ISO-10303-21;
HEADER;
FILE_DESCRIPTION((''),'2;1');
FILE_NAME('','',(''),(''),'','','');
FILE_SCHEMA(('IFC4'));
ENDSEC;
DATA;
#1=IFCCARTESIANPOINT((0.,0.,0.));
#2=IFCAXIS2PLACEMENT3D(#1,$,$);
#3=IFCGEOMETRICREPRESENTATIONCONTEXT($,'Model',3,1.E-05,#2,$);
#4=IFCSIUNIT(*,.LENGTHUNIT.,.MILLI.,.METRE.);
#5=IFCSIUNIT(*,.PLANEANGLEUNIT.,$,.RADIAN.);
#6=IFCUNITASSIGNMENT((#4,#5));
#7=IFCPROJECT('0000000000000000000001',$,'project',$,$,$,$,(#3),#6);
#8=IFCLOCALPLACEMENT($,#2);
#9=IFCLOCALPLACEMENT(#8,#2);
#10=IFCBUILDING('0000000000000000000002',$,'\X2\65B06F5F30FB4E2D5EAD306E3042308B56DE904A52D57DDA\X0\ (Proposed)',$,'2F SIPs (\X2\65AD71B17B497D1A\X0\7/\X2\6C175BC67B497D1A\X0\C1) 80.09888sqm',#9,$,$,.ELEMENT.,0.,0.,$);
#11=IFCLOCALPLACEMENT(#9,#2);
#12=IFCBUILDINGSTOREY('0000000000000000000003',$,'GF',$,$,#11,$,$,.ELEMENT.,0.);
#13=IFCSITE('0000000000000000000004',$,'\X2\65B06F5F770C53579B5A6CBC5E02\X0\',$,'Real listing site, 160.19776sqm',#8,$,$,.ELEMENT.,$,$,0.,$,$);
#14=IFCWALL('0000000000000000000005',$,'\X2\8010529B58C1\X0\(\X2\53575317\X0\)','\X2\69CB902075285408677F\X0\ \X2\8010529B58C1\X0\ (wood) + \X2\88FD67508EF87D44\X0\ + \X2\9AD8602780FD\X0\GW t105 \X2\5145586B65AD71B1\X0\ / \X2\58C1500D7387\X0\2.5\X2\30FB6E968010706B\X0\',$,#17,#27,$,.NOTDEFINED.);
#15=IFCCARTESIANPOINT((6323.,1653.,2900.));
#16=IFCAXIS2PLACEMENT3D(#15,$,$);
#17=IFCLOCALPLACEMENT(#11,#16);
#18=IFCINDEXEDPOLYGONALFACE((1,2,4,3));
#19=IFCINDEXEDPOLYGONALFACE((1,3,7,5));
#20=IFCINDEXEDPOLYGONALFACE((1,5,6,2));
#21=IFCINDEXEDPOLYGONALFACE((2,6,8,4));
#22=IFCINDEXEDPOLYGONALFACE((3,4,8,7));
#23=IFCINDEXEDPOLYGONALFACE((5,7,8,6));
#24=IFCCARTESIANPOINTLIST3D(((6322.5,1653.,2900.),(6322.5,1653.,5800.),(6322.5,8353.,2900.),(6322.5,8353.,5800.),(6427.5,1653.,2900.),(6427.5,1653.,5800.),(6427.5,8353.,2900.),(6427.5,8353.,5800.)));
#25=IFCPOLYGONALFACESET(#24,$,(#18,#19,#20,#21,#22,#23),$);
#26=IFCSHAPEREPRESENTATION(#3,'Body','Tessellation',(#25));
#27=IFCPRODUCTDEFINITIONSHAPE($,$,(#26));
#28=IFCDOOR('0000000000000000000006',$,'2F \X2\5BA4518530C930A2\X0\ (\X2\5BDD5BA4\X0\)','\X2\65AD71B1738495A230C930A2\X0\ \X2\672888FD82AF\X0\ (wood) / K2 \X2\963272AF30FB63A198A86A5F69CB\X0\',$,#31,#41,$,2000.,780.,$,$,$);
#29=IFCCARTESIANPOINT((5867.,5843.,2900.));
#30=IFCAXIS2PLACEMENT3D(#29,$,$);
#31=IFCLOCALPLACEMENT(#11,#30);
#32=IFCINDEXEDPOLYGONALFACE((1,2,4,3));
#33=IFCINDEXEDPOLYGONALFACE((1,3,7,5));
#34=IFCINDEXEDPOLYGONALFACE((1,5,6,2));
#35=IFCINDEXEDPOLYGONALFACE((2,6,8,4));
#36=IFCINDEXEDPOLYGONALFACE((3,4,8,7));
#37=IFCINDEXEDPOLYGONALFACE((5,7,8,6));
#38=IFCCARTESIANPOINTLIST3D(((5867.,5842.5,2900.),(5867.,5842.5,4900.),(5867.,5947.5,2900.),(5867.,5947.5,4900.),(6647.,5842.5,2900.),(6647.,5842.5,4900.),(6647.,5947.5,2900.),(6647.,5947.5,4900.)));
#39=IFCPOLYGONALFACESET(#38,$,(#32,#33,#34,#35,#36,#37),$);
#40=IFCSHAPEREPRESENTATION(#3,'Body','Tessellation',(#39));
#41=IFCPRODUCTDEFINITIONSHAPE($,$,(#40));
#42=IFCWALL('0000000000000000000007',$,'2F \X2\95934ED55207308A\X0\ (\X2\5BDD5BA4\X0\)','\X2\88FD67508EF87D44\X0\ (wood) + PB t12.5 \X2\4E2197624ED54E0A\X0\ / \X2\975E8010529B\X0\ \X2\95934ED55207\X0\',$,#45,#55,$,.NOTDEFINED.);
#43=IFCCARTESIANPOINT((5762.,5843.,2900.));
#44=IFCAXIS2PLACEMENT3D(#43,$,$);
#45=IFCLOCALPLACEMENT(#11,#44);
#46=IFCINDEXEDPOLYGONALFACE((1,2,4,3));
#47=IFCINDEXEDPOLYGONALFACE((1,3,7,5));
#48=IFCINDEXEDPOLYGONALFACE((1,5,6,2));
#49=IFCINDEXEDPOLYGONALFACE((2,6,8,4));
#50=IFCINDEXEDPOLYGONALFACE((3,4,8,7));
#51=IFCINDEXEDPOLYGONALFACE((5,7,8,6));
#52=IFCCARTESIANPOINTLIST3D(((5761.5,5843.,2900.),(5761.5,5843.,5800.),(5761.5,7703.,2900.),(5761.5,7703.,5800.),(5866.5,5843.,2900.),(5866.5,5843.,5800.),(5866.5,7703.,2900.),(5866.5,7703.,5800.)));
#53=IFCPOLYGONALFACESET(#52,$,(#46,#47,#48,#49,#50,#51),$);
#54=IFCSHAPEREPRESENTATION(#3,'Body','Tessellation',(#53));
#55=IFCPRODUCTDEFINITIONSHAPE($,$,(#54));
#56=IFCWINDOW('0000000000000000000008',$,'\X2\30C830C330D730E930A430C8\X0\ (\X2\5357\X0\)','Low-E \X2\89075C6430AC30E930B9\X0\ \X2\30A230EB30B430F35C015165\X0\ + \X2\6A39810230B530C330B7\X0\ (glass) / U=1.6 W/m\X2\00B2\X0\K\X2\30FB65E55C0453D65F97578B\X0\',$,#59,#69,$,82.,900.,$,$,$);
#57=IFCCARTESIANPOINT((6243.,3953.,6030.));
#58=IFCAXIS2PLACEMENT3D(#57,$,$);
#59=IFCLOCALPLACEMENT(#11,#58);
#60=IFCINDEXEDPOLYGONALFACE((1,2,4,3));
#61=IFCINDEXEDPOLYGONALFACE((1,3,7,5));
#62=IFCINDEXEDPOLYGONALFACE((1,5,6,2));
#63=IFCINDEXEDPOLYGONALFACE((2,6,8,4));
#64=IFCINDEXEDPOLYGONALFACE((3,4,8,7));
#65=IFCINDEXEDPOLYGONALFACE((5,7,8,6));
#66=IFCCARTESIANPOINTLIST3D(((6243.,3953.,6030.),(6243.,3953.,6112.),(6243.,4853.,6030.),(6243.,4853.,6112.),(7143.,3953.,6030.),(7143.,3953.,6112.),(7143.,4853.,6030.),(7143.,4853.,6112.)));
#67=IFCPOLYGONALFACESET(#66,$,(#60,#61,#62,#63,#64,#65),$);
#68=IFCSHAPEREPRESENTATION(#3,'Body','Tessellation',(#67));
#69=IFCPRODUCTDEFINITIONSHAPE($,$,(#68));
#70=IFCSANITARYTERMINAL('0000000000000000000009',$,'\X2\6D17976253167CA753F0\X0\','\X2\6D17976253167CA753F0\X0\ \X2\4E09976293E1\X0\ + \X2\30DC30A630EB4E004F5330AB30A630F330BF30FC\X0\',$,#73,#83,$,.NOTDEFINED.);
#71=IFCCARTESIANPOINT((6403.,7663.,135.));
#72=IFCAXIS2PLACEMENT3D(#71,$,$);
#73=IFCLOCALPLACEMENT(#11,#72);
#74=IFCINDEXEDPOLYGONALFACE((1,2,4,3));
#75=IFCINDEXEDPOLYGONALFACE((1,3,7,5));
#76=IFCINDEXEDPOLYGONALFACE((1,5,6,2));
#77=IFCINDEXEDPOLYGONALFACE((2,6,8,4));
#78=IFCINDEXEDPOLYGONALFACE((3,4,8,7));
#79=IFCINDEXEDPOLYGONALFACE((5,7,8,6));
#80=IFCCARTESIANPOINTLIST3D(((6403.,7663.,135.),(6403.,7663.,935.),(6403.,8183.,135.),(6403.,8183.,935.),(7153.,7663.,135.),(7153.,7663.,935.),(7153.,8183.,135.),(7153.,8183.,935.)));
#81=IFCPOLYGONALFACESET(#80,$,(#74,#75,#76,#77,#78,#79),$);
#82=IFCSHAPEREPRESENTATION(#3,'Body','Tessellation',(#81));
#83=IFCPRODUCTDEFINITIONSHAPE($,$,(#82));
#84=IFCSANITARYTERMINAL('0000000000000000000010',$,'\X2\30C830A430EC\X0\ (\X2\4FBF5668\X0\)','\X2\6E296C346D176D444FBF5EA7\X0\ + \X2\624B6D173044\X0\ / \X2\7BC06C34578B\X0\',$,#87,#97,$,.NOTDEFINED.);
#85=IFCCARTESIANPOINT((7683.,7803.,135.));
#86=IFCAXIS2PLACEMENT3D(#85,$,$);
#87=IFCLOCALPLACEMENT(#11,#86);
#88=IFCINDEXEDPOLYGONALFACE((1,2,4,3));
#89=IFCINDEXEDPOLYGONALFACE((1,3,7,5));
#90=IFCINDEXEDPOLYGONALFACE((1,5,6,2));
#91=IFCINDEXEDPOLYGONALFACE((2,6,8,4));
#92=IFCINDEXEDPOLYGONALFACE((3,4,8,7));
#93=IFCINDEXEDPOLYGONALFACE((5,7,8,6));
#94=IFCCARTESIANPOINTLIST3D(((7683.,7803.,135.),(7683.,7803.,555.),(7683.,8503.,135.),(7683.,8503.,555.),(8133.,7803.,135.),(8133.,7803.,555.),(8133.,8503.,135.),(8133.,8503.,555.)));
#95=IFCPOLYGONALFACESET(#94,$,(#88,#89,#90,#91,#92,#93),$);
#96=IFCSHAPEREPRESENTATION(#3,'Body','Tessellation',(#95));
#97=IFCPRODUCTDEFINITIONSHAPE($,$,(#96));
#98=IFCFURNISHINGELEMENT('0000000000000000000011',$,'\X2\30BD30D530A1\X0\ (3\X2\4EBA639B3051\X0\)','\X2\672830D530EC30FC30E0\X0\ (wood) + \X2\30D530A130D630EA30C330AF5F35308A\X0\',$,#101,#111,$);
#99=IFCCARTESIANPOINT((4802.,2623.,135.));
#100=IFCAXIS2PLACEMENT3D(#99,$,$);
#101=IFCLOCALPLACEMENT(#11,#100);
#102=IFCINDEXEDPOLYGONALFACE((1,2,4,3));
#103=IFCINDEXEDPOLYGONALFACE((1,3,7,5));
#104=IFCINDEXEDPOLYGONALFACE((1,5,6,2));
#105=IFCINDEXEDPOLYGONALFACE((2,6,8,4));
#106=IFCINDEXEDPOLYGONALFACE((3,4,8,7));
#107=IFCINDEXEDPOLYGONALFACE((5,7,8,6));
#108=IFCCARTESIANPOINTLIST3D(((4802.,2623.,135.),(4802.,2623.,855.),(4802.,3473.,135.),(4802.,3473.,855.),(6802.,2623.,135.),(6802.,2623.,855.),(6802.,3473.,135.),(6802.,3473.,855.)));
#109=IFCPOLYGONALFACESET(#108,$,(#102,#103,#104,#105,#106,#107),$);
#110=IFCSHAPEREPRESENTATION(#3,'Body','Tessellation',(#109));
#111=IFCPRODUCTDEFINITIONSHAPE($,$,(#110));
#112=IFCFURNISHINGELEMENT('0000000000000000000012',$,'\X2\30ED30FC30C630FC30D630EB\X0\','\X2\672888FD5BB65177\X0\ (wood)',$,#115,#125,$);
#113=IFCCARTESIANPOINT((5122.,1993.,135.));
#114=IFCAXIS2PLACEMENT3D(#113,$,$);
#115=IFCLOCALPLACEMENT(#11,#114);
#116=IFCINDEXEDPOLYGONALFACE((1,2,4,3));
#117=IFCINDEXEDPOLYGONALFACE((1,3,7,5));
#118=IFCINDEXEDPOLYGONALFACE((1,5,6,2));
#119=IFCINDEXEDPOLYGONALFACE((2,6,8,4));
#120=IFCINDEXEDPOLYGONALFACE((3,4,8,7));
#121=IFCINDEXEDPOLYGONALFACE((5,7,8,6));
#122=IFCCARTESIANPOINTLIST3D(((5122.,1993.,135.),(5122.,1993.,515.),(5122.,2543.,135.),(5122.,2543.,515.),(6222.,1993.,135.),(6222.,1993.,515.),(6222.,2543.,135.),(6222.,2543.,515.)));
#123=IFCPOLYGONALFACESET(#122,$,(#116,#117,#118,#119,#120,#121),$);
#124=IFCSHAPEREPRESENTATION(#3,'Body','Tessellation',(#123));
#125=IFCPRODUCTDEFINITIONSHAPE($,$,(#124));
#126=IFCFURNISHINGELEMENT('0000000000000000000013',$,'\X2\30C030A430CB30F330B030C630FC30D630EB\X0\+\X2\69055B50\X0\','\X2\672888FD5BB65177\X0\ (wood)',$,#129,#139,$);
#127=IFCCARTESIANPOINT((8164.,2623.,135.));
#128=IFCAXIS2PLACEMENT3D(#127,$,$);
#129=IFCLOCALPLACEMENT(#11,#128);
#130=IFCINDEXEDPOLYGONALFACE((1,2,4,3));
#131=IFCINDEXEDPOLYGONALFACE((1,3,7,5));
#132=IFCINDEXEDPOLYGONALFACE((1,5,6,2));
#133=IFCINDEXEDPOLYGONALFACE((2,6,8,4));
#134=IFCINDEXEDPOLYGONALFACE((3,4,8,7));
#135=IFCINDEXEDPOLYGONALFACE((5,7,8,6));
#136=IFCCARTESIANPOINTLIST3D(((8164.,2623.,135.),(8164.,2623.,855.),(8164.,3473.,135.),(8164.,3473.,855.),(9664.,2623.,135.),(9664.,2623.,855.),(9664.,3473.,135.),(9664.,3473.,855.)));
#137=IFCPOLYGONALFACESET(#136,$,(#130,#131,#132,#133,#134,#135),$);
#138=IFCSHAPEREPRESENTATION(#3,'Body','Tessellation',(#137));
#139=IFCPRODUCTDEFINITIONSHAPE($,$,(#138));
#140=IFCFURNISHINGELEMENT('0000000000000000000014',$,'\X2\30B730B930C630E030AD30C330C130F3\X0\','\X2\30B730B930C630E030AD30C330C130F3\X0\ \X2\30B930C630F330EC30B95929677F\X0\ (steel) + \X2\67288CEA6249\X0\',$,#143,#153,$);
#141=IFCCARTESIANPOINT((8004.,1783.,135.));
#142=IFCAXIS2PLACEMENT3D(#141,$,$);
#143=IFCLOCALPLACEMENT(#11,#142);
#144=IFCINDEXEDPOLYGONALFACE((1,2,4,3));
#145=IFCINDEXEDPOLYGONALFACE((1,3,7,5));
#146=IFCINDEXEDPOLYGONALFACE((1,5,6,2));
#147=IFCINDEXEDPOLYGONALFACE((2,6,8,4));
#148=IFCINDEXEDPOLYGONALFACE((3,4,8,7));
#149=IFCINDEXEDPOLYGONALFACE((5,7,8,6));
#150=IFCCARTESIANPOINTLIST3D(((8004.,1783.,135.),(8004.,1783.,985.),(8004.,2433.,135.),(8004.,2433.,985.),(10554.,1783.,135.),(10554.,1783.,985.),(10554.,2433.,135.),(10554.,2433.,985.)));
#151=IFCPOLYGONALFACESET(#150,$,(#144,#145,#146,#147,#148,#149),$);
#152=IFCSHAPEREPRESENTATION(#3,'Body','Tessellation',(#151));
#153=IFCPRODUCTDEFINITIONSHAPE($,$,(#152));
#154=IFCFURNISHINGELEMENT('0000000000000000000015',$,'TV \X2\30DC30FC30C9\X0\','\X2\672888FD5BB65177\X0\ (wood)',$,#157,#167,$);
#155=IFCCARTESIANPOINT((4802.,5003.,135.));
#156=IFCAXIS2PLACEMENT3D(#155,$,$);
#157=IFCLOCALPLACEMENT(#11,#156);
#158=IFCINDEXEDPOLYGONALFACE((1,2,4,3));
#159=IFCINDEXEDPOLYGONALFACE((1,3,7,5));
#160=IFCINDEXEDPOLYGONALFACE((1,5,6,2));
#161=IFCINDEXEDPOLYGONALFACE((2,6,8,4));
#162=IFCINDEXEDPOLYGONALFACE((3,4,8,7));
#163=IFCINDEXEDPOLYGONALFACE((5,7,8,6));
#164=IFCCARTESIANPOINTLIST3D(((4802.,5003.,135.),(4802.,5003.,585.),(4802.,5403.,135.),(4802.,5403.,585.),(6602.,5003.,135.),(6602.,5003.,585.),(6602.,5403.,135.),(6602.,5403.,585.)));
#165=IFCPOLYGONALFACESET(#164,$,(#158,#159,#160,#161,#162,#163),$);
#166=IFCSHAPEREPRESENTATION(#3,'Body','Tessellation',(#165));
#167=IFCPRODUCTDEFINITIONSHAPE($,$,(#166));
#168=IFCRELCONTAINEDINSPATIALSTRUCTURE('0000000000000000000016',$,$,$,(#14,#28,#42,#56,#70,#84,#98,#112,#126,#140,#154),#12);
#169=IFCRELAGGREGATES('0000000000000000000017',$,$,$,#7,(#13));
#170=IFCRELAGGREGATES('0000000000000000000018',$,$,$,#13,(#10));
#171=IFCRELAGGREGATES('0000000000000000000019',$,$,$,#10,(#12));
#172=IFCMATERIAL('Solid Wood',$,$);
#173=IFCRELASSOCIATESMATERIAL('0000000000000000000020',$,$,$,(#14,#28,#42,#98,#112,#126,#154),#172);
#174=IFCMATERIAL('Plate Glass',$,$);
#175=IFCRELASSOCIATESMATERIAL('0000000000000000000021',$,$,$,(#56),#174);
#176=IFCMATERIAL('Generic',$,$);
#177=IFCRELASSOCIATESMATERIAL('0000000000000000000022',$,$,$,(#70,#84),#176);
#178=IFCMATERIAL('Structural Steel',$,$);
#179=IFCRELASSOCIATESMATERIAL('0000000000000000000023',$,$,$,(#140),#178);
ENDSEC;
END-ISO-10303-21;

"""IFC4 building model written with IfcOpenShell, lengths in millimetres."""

from ifc_helpers import new_model, si_unit, frame, frame_2d, origin, place, context, project, spatial, rectangle, extrude, material, element, fill, save


model = new_model("IFC4")

# Units and contexts
model_context = context("Model", 3, precision=1e-05, world=origin())
ifc_project = project(units=[si_unit("LENGTHUNIT", "METRE", prefix="MILLI"), si_unit("PLANEANGLEUNIT", "RADIAN")], contexts=[model_context])

# Site, building, storey
site_placement = place(None, origin())
site = spatial("IfcSite", under=ifc_project, at=site_placement, Name="新潟県南魚沼市", ObjectType="Real listing site, 160.19776sqm", CompositionType="ELEMENT", RefElevation=0.0)
building_placement = place(site_placement, origin())
building = spatial("IfcBuilding", under=site, at=building_placement, Name="新潟・中庭のある回遊動線 (Proposed)", ObjectType="2F SIPs (断熱等級7/気密等級C1) 80.09888sqm", CompositionType="ELEMENT", ElevationOfRefHeight=0.0, ElevationOfTerrain=0.0)
storey_placement = place(building_placement, origin())
storey = spatial("IfcBuildingStorey", under=building, at=storey_placement, Name="GF", CompositionType="ELEMENT", Elevation=0.0)

# Shared definitions
ifc_material_1 = material(Name="Solid Wood")

# Wall, opening, door
wall_1_placement = place(storey_placement, frame((6323.0, 1653.0, 2900.0)))
wall_1 = element("IfcWall", 1, at=wall_1_placement, inside=storey, material=ifc_material_1, Name="耐力壁(南北)", Description="構造用合板 耐力壁 (wood) + 製材軸組 + 高性能GW t105 充填断熱 / 壁倍率2.5・準耐火", PredefinedType="NOTDEFINED", context=model_context, shape_type="SweptSolid", body=[
    extrude(rectangle(XDim=105.0, YDim=6700.0, at=frame_2d((52.0, 3350.0))), frame((6323.0, 1653.0, 2900.0)), (0.0, 0.0, 1.0), 2900.0),
])
opening_1_placement = place(storey_placement, frame((5867.0, 5843.0, 2900.0)))
opening_1 = element("IfcOpeningElement", 2, at=opening_1_placement, cuts=wall_1, PredefinedType="NOTDEFINED", context=model_context, shape_type="SweptSolid", body=[
    extrude(rectangle(XDim=780.0, YDim=105.0, at=frame_2d((390.0, 52.0))), frame((5867.0, 5843.0, 2900.0)), (0.0, 0.0, 1.0), 2000.0),
])
door_1_placement = place(storey_placement, frame((5867.0, 5843.0, 2900.0)))
door_1 = element("IfcDoor", 3, at=door_1_placement, inside=storey, material=ifc_material_1, Name="2F 室内ドア (寝室)", Description="断熱玄関ドア 木製芯 (wood) / K2 防犯・採風機構", OverallHeight=2000.0, OverallWidth=780.0, context=model_context, shape_type="SweptSolid", body=[
    extrude(rectangle(XDim=780.0, YDim=105.0, at=frame_2d((390.0, 52.0))), frame((5867.0, 5843.0, 2900.0)), (0.0, 0.0, 1.0), 2000.0),
])
fill(opening_1, door_1)

# Wall
wall_2_placement = place(storey_placement, frame((5762.0, 5843.0, 2900.0)))
element("IfcWall", 4, at=wall_2_placement, inside=storey, material=ifc_material_1, Name="2F 間仕切り (寝室)", Description="製材軸組 (wood) + PB t12.5 両面仕上 / 非耐力 間仕切", PredefinedType="NOTDEFINED", context=model_context, shape_type="SweptSolid", body=[
    extrude(rectangle(XDim=105.0, YDim=1860.0, at=frame_2d((52.0, 930.0))), frame((5762.0, 5843.0, 2900.0)), (0.0, 0.0, 1.0), 2900.0),
])

# Window
ifc_material_2 = material(Name="Plate Glass")
window_placement = place(storey_placement, frame((6243.0, 3953.0, 6030.0)))
element("IfcWindow", 5, at=window_placement, inside=storey, material=ifc_material_2, Name="トップライト (南)", Description="Low-E 複層ガラス アルゴン封入 + 樹脂サッシ (glass) / U=1.6 W/m²K・日射取得型", OverallHeight=82.0, OverallWidth=900.0, context=model_context, shape_type="SweptSolid", body=[
    extrude(rectangle(XDim=900.0, YDim=900.0, at=frame_2d((450.0, 450.0))), frame((6243.0, 3953.0, 6030.0)), (0.0, 0.0, 1.0), 82.0),
])

# Sanitary terminals
ifc_material_3 = material(Name="Generic")
sanitary_terminal_1_placement = place(storey_placement, frame((6403.0, 7663.0, 135.0)))
element("IfcSanitaryTerminal", 6, at=sanitary_terminal_1_placement, inside=storey, material=ifc_material_3, Name="洗面化粧台", Description="洗面化粧台 三面鏡 + ボウル一体カウンター", PredefinedType="NOTDEFINED", context=model_context, shape_type="SweptSolid", body=[
    extrude(rectangle(XDim=750.0, YDim=520.0, at=frame_2d((375.0, 260.0))), frame((6403.0, 7663.0, 135.0)), (0.0, 0.0, 1.0), 800.0),
])
sanitary_terminal_2_placement = place(storey_placement, frame((7683.0, 7803.0, 135.0)))
element("IfcSanitaryTerminal", 7, at=sanitary_terminal_2_placement, inside=storey, material=ifc_material_3, Name="トイレ (便器)", Description="温水洗浄便座 + 手洗い / 節水型", PredefinedType="NOTDEFINED", context=model_context, shape_type="SweptSolid", body=[
    extrude(rectangle(XDim=450.0, YDim=700.0, at=frame_2d((225.0, 350.0))), frame((7683.0, 7803.0, 135.0)), (0.0, 0.0, 1.0), 420.0),
])

# Furnishing elements
furnishing_1_placement = place(storey_placement, frame((4802.0, 2623.0, 135.0)))
element("IfcFurnishingElement", 8, at=furnishing_1_placement, inside=storey, material=ifc_material_1, Name="ソファ (3人掛け)", Description="木フレーム (wood) + ファブリック張り", context=model_context, shape_type="SweptSolid", body=[
    extrude(rectangle(XDim=2000.0, YDim=850.0, at=frame_2d((1000.0, 425.0))), frame((4802.0, 2623.0, 135.0)), (0.0, 0.0, 1.0), 720.0),
])
furnishing_2_placement = place(storey_placement, frame((5122.0, 1993.0, 135.0)))
element("IfcFurnishingElement", 9, at=furnishing_2_placement, inside=storey, material=ifc_material_1, Name="ローテーブル", Description="木製家具 (wood)", context=model_context, shape_type="SweptSolid", body=[
    extrude(rectangle(XDim=1100.0, YDim=550.0, at=frame_2d((550.0, 275.0))), frame((5122.0, 1993.0, 135.0)), (0.0, 0.0, 1.0), 380.0),
])
furnishing_3_placement = place(storey_placement, frame((8164.0, 2623.0, 135.0)))
element("IfcFurnishingElement", 10, at=furnishing_3_placement, inside=storey, material=ifc_material_1, Name="ダイニングテーブル+椅子", Description="木製家具 (wood)", context=model_context, shape_type="SweptSolid", body=[
    extrude(rectangle(XDim=1500.0, YDim=850.0, at=frame_2d((750.0, 425.0))), frame((8164.0, 2623.0, 135.0)), (0.0, 0.0, 1.0), 720.0),
])
ifc_material_4 = material(Name="Structural Steel")
furnishing_4_placement = place(storey_placement, frame((8004.0, 1783.0, 135.0)))
element("IfcFurnishingElement", 11, at=furnishing_4_placement, inside=storey, material=ifc_material_4, Name="システムキッチン", Description="システムキッチン ステンレス天板 (steel) + 木質扉", context=model_context, shape_type="SweptSolid", body=[
    extrude(rectangle(XDim=2550.0, YDim=650.0, at=frame_2d((1275.0, 325.0))), frame((8004.0, 1783.0, 135.0)), (0.0, 0.0, 1.0), 850.0),
])
furnishing_5_placement = place(storey_placement, frame((4802.0, 5003.0, 135.0)))
element("IfcFurnishingElement", 12, at=furnishing_5_placement, inside=storey, material=ifc_material_1, Name="TV ボード", Description="木製家具 (wood)", context=model_context, shape_type="SweptSolid", body=[
    extrude(rectangle(XDim=1800.0, YDim=400.0, at=frame_2d((900.0, 200.0))), frame((4802.0, 5003.0, 135.0)), (0.0, 0.0, 1.0), 450.0),
])

save(model, "model.ifc")
